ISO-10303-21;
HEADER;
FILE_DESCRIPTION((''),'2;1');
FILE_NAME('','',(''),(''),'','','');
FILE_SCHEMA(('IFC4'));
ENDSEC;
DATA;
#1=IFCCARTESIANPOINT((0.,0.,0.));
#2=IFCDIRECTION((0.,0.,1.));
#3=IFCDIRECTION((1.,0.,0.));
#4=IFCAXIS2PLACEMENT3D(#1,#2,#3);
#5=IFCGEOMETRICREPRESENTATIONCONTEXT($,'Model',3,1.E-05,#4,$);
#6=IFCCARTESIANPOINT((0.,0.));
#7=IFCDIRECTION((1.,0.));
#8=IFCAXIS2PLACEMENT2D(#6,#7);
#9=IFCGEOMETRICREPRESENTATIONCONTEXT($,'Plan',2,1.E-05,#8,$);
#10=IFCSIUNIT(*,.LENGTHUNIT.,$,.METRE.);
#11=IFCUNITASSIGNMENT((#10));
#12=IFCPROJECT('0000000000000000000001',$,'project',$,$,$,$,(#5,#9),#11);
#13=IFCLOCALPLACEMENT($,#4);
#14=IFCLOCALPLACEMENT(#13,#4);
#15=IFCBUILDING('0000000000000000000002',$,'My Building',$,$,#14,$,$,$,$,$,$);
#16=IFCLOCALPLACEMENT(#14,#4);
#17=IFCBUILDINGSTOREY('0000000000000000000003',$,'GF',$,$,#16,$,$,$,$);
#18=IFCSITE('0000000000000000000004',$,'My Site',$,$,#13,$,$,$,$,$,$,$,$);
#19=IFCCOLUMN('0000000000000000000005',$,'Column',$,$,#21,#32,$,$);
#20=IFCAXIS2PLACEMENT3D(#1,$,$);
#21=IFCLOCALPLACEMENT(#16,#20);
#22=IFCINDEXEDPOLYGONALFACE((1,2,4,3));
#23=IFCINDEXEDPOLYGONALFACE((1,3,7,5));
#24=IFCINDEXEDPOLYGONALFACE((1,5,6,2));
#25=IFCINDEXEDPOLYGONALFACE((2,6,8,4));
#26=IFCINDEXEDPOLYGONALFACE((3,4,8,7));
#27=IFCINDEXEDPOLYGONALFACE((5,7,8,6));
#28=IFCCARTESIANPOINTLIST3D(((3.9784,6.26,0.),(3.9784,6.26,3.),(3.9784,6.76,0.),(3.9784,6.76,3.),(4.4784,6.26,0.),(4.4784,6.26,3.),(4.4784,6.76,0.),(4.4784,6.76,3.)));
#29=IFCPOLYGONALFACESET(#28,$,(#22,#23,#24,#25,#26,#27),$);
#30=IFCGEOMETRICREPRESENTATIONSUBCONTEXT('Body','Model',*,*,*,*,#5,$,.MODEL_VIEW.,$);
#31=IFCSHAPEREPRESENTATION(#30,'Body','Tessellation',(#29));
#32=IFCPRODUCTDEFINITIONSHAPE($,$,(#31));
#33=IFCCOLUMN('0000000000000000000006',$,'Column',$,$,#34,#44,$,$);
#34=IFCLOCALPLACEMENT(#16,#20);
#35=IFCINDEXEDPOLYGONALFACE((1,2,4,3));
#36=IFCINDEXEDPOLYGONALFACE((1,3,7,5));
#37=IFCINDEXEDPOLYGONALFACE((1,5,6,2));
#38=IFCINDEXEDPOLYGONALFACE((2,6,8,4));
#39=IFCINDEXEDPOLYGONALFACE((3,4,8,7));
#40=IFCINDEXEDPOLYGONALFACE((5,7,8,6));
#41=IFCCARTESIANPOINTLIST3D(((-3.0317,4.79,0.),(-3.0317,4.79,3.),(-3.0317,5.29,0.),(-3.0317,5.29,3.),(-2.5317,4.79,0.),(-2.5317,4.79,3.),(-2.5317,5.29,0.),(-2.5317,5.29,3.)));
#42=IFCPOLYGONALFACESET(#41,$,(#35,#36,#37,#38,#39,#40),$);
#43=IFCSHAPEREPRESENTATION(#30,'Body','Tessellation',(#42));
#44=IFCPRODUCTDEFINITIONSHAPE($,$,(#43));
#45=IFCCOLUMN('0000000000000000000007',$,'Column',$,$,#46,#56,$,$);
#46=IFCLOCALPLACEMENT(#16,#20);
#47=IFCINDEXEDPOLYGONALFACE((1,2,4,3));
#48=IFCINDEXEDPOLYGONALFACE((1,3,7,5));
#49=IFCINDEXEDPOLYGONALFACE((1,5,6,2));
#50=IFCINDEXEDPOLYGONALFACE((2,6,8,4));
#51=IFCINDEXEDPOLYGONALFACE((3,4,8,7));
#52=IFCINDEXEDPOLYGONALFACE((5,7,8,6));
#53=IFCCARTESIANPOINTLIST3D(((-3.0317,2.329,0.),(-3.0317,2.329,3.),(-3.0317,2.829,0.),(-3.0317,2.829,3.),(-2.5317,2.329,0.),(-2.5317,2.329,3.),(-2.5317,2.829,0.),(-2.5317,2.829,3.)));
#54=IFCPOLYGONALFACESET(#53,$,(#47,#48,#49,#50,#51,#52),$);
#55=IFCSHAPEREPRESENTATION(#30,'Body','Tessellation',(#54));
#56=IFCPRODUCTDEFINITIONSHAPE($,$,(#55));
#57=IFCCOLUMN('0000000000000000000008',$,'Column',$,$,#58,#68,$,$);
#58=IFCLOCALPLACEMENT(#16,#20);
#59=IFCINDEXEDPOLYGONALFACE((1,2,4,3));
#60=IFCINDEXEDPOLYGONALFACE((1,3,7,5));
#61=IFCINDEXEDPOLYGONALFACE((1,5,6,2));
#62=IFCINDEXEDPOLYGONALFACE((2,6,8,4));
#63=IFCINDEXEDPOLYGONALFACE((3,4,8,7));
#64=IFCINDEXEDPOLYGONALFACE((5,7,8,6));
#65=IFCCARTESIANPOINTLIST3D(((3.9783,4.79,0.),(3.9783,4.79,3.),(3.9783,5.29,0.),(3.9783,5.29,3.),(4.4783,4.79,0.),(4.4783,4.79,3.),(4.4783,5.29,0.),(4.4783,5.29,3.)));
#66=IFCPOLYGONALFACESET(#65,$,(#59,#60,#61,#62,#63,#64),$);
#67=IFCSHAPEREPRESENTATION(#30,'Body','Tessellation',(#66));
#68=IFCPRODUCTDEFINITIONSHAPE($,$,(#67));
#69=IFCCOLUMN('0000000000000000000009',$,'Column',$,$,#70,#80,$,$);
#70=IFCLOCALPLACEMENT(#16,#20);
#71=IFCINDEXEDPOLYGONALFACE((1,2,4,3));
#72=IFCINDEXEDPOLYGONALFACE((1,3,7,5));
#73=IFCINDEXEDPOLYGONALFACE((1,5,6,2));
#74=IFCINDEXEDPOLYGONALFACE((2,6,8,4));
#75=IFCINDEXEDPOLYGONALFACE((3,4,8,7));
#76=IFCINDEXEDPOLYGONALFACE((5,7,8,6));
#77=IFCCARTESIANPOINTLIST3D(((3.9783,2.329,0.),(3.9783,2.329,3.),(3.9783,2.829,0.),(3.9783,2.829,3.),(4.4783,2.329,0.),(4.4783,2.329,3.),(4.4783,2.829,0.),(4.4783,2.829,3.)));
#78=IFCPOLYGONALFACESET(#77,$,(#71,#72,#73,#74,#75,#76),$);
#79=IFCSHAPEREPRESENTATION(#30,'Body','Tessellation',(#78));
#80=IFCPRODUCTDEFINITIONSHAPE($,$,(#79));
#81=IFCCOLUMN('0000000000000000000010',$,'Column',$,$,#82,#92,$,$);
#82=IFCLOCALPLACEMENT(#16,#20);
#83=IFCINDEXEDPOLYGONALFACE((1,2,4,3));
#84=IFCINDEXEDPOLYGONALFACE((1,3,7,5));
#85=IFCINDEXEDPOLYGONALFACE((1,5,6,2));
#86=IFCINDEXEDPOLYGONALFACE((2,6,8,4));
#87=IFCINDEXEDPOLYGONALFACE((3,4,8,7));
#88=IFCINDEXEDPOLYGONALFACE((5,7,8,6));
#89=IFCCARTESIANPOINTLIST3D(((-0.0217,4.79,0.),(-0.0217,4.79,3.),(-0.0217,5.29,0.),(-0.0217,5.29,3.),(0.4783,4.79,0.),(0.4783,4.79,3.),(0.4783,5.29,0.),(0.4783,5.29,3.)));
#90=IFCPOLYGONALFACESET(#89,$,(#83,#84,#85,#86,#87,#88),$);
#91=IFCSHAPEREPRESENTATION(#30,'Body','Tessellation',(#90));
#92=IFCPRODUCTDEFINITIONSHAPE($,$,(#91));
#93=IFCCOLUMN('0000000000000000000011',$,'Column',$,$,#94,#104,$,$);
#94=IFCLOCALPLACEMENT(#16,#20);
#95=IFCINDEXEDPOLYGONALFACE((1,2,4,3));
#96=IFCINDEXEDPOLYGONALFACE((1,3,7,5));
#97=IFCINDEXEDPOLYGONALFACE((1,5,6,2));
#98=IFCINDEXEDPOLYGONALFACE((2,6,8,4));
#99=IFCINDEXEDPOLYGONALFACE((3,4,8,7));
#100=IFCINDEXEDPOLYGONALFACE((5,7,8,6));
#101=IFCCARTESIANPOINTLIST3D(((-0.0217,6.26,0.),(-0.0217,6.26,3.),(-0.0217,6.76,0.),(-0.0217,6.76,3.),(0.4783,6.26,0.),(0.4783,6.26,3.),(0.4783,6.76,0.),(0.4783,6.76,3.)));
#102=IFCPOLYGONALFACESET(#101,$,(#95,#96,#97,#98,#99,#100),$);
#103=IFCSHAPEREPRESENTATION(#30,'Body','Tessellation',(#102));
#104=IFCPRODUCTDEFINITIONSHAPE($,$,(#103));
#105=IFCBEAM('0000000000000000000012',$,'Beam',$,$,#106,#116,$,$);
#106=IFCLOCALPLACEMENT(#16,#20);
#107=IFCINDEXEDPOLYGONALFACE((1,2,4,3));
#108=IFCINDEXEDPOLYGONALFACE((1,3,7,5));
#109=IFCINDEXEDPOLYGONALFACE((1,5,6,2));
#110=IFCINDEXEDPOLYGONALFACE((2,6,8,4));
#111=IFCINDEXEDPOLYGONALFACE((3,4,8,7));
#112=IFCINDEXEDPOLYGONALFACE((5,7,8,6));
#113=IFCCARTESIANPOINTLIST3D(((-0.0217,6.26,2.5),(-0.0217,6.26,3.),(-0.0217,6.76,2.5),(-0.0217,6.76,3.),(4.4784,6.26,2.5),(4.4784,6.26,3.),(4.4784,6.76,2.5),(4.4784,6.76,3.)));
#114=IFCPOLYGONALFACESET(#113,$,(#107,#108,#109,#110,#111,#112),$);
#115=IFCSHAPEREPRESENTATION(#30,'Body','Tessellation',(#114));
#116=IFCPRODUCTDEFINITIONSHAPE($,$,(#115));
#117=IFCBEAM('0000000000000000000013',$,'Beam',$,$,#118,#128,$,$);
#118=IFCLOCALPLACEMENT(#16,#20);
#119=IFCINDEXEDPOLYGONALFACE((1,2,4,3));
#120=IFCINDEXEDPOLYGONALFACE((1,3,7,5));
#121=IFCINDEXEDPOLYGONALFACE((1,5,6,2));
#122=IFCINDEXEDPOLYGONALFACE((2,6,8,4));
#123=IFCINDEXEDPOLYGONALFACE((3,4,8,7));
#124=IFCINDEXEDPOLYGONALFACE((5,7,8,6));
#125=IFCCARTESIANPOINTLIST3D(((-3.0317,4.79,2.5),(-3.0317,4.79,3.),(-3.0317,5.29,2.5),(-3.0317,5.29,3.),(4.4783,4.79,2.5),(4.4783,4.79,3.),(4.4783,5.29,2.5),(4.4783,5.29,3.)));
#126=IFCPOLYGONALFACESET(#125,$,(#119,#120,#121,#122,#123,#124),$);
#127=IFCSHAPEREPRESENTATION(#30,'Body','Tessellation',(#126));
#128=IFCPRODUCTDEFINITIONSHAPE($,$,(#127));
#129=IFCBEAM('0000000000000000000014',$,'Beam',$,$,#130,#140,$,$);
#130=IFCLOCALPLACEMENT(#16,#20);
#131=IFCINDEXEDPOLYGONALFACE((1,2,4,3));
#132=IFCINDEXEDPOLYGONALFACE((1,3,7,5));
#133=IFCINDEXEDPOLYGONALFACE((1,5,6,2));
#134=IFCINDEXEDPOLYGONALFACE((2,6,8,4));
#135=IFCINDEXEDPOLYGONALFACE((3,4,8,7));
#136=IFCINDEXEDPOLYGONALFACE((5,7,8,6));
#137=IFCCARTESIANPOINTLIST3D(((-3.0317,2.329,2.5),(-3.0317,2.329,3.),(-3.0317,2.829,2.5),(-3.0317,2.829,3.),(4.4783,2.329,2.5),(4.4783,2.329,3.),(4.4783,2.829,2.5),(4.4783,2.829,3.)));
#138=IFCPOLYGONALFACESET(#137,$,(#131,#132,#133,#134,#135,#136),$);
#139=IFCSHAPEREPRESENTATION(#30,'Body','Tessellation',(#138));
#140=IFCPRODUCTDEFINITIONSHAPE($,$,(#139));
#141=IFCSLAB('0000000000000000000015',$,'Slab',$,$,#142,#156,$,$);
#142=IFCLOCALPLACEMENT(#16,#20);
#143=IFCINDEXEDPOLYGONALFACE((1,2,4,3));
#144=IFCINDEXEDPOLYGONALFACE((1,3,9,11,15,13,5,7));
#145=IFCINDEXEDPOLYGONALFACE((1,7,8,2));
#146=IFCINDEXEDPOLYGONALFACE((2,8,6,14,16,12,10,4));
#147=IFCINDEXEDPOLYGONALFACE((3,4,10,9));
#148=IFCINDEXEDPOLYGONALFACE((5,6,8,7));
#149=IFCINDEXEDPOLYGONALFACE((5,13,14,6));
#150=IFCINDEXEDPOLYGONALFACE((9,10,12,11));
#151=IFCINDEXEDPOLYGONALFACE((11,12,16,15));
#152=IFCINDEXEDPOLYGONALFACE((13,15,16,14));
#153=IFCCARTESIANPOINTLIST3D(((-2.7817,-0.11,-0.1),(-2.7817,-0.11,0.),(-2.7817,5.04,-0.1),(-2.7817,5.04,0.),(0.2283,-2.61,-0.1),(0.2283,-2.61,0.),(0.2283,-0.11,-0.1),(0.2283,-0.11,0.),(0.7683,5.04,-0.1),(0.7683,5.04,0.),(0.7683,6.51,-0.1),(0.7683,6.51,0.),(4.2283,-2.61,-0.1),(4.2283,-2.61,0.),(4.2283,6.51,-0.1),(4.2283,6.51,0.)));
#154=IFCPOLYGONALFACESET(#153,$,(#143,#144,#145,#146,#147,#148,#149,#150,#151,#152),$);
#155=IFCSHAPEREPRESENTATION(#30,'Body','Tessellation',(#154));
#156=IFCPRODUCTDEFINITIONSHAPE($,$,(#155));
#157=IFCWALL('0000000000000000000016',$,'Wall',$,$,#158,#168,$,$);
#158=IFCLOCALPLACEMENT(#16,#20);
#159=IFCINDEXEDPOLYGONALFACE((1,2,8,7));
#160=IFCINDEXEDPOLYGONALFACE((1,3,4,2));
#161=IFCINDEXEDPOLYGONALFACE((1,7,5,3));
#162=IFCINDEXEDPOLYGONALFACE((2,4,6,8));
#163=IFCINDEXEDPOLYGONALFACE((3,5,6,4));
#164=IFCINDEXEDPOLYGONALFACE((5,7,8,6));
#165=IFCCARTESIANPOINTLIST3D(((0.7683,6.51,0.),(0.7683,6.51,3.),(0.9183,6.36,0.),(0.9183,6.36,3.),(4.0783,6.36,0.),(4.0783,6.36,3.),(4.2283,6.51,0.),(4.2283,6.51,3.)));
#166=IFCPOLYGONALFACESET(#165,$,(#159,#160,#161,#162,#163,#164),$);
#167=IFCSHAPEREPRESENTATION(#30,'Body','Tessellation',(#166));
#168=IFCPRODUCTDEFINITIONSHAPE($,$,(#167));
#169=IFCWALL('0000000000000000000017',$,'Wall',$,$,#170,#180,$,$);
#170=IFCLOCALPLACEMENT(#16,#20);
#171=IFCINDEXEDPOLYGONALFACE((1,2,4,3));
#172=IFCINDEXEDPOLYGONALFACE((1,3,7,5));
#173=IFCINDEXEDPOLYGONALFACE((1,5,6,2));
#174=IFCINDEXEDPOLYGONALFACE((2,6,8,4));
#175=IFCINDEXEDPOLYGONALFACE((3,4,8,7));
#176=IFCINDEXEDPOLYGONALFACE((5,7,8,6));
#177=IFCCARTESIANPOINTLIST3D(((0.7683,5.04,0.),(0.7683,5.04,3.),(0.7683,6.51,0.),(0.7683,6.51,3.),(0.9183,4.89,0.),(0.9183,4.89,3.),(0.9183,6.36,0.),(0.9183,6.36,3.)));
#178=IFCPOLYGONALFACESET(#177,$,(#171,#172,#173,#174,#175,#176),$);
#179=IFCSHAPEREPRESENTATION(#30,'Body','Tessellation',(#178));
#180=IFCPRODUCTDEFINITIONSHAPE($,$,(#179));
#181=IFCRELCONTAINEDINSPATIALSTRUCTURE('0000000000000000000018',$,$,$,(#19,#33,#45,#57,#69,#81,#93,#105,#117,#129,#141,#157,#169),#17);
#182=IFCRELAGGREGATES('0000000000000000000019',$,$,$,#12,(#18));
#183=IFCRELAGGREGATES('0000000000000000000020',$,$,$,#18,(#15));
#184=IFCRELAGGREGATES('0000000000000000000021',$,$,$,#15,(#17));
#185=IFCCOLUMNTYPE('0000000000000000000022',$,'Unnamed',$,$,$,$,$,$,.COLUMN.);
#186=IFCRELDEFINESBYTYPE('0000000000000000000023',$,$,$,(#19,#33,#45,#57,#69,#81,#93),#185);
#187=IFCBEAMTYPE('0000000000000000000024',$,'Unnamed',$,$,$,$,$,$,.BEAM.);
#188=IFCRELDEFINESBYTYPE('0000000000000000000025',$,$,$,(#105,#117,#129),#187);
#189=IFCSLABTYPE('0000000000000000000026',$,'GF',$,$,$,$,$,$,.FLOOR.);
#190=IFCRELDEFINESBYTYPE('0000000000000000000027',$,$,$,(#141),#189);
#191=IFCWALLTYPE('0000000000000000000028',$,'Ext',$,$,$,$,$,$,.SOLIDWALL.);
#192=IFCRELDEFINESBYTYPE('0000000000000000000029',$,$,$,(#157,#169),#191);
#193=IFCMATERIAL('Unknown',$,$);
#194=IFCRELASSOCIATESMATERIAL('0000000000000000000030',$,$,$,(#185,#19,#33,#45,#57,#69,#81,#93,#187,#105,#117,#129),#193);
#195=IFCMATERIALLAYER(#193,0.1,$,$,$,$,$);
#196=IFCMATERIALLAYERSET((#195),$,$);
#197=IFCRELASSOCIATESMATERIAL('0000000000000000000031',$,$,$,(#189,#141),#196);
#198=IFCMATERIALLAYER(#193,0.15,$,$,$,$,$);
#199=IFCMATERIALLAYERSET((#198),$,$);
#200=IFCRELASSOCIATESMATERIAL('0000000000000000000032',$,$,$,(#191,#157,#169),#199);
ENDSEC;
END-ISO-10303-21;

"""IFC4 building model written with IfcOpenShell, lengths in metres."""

from ifc_helpers import new_model, si_unit, frame, origin_with_axes, origin_2d_with_axis, place, context, subcontext, project, spatial, line, indexed_curve, rectangle, outline, extrude, material, layer, layer_set, layer_usage, material_profile, profile_set, profile_usage, type_object, element, save


model = new_model("IFC4")

# Units and contexts
model_context = context("Model", 3, precision=1e-05, world=origin_with_axes())
plan_context = context("Plan", 2, precision=1e-05, world=origin_2d_with_axis())
body_context_1 = subcontext(model_context, "Body", "Model", "MODEL_VIEW")
ifc_project = project(units=[si_unit("LENGTHUNIT", "METRE")], contexts=[model_context, plan_context])

# Site, building, storey
site_placement = place(None, origin_with_axes())
site = spatial("IfcSite", under=ifc_project, at=site_placement, Name="My Site")
building_placement = place(site_placement, origin_with_axes())
building = spatial("IfcBuilding", under=site, at=building_placement, Name="My Building")
storey_placement = place(building_placement, origin_with_axes())
storey = spatial("IfcBuildingStorey", under=building, at=storey_placement, Name="GF")

# Columns
ifc_material = material(Name="Unknown")
ifc_material_profile_1 = material_profile(ifc_material, rectangle(XDim=0.5, YDim=0.5))
ifc_profile_set_1 = profile_set([ifc_material_profile_1])
ifc_profile_usage_1 = profile_usage(ifc_profile_set_1, cardinal=5)
column_type = type_object("IfcColumnType", Name="Unnamed", PredefinedType="COLUMN", material=ifc_profile_set_1)
column_1_placement = place(storey_placement, frame((4.2284, 6.51, 0.0), z_axis=(0.0, 0.0, 1.0), x_axis=(1.0, 0.0, 0.0)))
element("IfcColumn", 1, at=column_1_placement, inside=storey, type_object=column_type, material=ifc_profile_usage_1, Name="Column", context=body_context_1, shape_type="SweptSolid", body=[
    extrude(rectangle(XDim=0.5, YDim=0.5), origin_with_axes(), (0.0, 0.0, 1.0), 3.0),
])
ifc_profile_usage_2 = profile_usage(ifc_profile_set_1, cardinal=5)
column_2_placement = place(storey_placement, frame((-2.7817, 5.04, 0.0), z_axis=(0.0, 0.0, 1.0), x_axis=(1.0, 0.0, 0.0)))
element("IfcColumn", 2, at=column_2_placement, inside=storey, type_object=column_type, material=ifc_profile_usage_2, Name="Column", context=body_context_1, shape_type="SweptSolid", body=[
    extrude(rectangle(XDim=0.5, YDim=0.5), origin_with_axes(), (0.0, 0.0, 1.0), 3.0),
])
ifc_profile_usage_3 = profile_usage(ifc_profile_set_1, cardinal=5)
column_3_placement = place(storey_placement, frame((-2.7817, 2.579, 0.0), z_axis=(0.0, 0.0, 1.0), x_axis=(1.0, 0.0, 0.0)))
element("IfcColumn", 3, at=column_3_placement, inside=storey, type_object=column_type, material=ifc_profile_usage_3, Name="Column", context=body_context_1, shape_type="SweptSolid", body=[
    extrude(rectangle(XDim=0.5, YDim=0.5), origin_with_axes(), (0.0, 0.0, 1.0), 3.0),
])
ifc_profile_usage_4 = profile_usage(ifc_profile_set_1, cardinal=5)
column_4_placement = place(storey_placement, frame((4.2283, 5.04, 0.0), z_axis=(0.0, 0.0, 1.0), x_axis=(1.0, 0.0, 0.0)))
element("IfcColumn", 4, at=column_4_placement, inside=storey, type_object=column_type, material=ifc_profile_usage_4, Name="Column", context=body_context_1, shape_type="SweptSolid", body=[
    extrude(rectangle(XDim=0.5, YDim=0.5), origin_with_axes(), (0.0, 0.0, 1.0), 3.0),
])
ifc_profile_usage_5 = profile_usage(ifc_profile_set_1, cardinal=5)
column_5_placement = place(storey_placement, frame((4.2283, 2.579, 0.0), z_axis=(0.0, 0.0, 1.0), x_axis=(1.0, 0.0, 0.0)))
element("IfcColumn", 5, at=column_5_placement, inside=storey, type_object=column_type, material=ifc_profile_usage_5, Name="Column", context=body_context_1, shape_type="SweptSolid", body=[
    extrude(rectangle(XDim=0.5, YDim=0.5), origin_with_axes(), (0.0, 0.0, 1.0), 3.0),
])
ifc_profile_usage_6 = profile_usage(ifc_profile_set_1, cardinal=5)
column_6_placement = place(storey_placement, frame((0.2283, 5.04, 0.0), z_axis=(0.0, 0.0, 1.0), x_axis=(1.0, 0.0, 0.0)))
element("IfcColumn", 6, at=column_6_placement, inside=storey, type_object=column_type, material=ifc_profile_usage_6, Name="Column", context=body_context_1, shape_type="SweptSolid", body=[
    extrude(rectangle(XDim=0.5, YDim=0.5), origin_with_axes(), (0.0, 0.0, 1.0), 3.0),
])
ifc_profile_usage_7 = profile_usage(ifc_profile_set_1, cardinal=5)
column_7_placement = place(storey_placement, frame((0.2283, 6.51, 0.0), z_axis=(0.0, 0.0, 1.0), x_axis=(1.0, 0.0, 0.0)))
element("IfcColumn", 7, at=column_7_placement, inside=storey, type_object=column_type, material=ifc_profile_usage_7, Name="Column", context=body_context_1, shape_type="SweptSolid", body=[
    extrude(rectangle(XDim=0.5, YDim=0.5), origin_with_axes(), (0.0, 0.0, 1.0), 3.0),
])

# Beams
ifc_material_profile_2 = material_profile(ifc_material, rectangle(XDim=0.5, YDim=0.5))
ifc_profile_set_2 = profile_set([ifc_material_profile_2])
ifc_profile_usage_8 = profile_usage(ifc_profile_set_2, cardinal=9)
beam_type = type_object("IfcBeamType", Name="Unnamed", PredefinedType="BEAM", material=ifc_profile_set_2)
beam_1_placement = place(storey_placement, frame((4.4784, 6.76, 3.0), z_axis=(-1.0, 0.0, 0.0), x_axis=(0.0, -1.0, 0.0)))
element("IfcBeam", 8, at=beam_1_placement, inside=storey, type_object=beam_type, material=ifc_profile_usage_8, Name="Beam", context=body_context_1, shape_type="SweptSolid", body=[
    extrude(rectangle(XDim=0.5, YDim=0.5), frame((0.25, -0.25, 0.0), z_axis=(0.0, 0.0, 1.0), x_axis=(1.0, 0.0, 0.0)), (0.0, 0.0, 1.0), 4.5),
])
ifc_profile_usage_9 = profile_usage(ifc_profile_set_2, cardinal=9)
beam_2_placement = place(storey_placement, frame((4.4783, 5.29, 3.0), z_axis=(-1.0, 0.0, 0.0), x_axis=(0.0, -1.0, 0.0)))
element("IfcBeam", 9, at=beam_2_placement, inside=storey, type_object=beam_type, material=ifc_profile_usage_9, Name="Beam", context=body_context_1, shape_type="SweptSolid", body=[
    extrude(rectangle(XDim=0.5, YDim=0.5), frame((0.25, -0.25, 0.0), z_axis=(0.0, 0.0, 1.0), x_axis=(1.0, 0.0, 0.0)), (0.0, 0.0, 1.0), 7.51),
])
ifc_profile_usage_10 = profile_usage(ifc_profile_set_2, cardinal=9)
beam_3_placement = place(storey_placement, frame((4.4783, 2.829, 3.0), z_axis=(-1.0, 0.0, 0.0), x_axis=(0.0, -1.0, 0.0)))
element("IfcBeam", 10, at=beam_3_placement, inside=storey, type_object=beam_type, material=ifc_profile_usage_10, Name="Beam", context=body_context_1, shape_type="SweptSolid", body=[
    extrude(rectangle(XDim=0.5, YDim=0.5), frame((0.25, -0.25, 0.0), z_axis=(0.0, 0.0, 1.0), x_axis=(1.0, 0.0, 0.0)), (0.0, 0.0, 1.0), 7.51),
])

# Slab
ifc_layer_1 = layer(ifc_material, 0.1)
ifc_layer_set_1 = layer_set([ifc_layer_1])
ifc_layer_usage_1 = layer_usage(ifc_layer_set_1, "AXIS3", "POSITIVE", -0.1)
slab_type = type_object("IfcSlabType", Name="GF", PredefinedType="FLOOR", material=ifc_layer_set_1)
slab_placement = place(storey_placement, frame((-2.7817, 5.04, 0.0), z_axis=(0.0, 0.0, 1.0), x_axis=(1.0, 0.0, 0.0)))
element("IfcSlab", 11, at=slab_placement, inside=storey, type_object=slab_type, material=ifc_layer_usage_1, Name="Slab", context=body_context_1, shape_type="SweptSolid", body=[
    extrude(outline(indexed_curve([(0.0, 0.0), (3.55, 0.0), (3.55, 1.47), (7.01, 1.47), (7.01, -7.65), (3.01, -7.65), (3.01, -5.15), (0.0, -5.15), (0.0, 0.0)])), frame((0.0, 0.0, -0.1), z_axis=(0.0, 0.0, 1.0), x_axis=(1.0, 0.0, 0.0)), (0.0, 0.0, 1.0), 0.1),
])

# Walls
ifc_layer_2 = layer(ifc_material, 0.15)
ifc_layer_set_2 = layer_set([ifc_layer_2])
ifc_layer_usage_2 = layer_usage(ifc_layer_set_2, "AXIS2", "POSITIVE", 0.0)
wall_type_1 = type_object("IfcWallType", Name="Ext", PredefinedType="SOLIDWALL", material=ifc_layer_set_2)
wall_1_placement = place(storey_placement, frame((4.2283, 6.51, 0.0), z_axis=(0.0, 0.0, 1.0), x_axis=(-1.0, 0.0, 0.0)))
element("IfcWall", 12, at=wall_1_placement, inside=storey, type_object=wall_type_1, material=ifc_layer_usage_2, Name="Wall", context=body_context_1, shape_type="SweptSolid", body=[
    extrude(outline(indexed_curve([(0.0, 0.0), (0.15, 0.15), (3.31, 0.15), (3.46, 0.0)], segments=[line(1, 2, 3, 4, 1)])), origin_with_axes(), (0.0, 0.0, 1.0), 3.0),
])
ifc_layer_usage_3 = layer_usage(ifc_layer_set_2, "AXIS2", "POSITIVE", 0.0)
wall_2_placement = place(storey_placement, frame((0.7683, 6.51, 0.0), z_axis=(0.0, 0.0, 1.0), x_axis=(0.0, -1.0, 0.0)))
element("IfcWall", 13, at=wall_2_placement, inside=storey, type_object=wall_type_1, material=ifc_layer_usage_3, Name="Wall", context=body_context_1, shape_type="SweptSolid", body=[
    extrude(outline(indexed_curve([(0.0, 0.0), (0.15, 0.15), (1.62, 0.15), (1.47, 0.0)], segments=[line(1, 2, 3, 4, 1)])), origin_with_axes(), (0.0, 0.0, 1.0), 3.0),
])

save(model, "model.ifc")
